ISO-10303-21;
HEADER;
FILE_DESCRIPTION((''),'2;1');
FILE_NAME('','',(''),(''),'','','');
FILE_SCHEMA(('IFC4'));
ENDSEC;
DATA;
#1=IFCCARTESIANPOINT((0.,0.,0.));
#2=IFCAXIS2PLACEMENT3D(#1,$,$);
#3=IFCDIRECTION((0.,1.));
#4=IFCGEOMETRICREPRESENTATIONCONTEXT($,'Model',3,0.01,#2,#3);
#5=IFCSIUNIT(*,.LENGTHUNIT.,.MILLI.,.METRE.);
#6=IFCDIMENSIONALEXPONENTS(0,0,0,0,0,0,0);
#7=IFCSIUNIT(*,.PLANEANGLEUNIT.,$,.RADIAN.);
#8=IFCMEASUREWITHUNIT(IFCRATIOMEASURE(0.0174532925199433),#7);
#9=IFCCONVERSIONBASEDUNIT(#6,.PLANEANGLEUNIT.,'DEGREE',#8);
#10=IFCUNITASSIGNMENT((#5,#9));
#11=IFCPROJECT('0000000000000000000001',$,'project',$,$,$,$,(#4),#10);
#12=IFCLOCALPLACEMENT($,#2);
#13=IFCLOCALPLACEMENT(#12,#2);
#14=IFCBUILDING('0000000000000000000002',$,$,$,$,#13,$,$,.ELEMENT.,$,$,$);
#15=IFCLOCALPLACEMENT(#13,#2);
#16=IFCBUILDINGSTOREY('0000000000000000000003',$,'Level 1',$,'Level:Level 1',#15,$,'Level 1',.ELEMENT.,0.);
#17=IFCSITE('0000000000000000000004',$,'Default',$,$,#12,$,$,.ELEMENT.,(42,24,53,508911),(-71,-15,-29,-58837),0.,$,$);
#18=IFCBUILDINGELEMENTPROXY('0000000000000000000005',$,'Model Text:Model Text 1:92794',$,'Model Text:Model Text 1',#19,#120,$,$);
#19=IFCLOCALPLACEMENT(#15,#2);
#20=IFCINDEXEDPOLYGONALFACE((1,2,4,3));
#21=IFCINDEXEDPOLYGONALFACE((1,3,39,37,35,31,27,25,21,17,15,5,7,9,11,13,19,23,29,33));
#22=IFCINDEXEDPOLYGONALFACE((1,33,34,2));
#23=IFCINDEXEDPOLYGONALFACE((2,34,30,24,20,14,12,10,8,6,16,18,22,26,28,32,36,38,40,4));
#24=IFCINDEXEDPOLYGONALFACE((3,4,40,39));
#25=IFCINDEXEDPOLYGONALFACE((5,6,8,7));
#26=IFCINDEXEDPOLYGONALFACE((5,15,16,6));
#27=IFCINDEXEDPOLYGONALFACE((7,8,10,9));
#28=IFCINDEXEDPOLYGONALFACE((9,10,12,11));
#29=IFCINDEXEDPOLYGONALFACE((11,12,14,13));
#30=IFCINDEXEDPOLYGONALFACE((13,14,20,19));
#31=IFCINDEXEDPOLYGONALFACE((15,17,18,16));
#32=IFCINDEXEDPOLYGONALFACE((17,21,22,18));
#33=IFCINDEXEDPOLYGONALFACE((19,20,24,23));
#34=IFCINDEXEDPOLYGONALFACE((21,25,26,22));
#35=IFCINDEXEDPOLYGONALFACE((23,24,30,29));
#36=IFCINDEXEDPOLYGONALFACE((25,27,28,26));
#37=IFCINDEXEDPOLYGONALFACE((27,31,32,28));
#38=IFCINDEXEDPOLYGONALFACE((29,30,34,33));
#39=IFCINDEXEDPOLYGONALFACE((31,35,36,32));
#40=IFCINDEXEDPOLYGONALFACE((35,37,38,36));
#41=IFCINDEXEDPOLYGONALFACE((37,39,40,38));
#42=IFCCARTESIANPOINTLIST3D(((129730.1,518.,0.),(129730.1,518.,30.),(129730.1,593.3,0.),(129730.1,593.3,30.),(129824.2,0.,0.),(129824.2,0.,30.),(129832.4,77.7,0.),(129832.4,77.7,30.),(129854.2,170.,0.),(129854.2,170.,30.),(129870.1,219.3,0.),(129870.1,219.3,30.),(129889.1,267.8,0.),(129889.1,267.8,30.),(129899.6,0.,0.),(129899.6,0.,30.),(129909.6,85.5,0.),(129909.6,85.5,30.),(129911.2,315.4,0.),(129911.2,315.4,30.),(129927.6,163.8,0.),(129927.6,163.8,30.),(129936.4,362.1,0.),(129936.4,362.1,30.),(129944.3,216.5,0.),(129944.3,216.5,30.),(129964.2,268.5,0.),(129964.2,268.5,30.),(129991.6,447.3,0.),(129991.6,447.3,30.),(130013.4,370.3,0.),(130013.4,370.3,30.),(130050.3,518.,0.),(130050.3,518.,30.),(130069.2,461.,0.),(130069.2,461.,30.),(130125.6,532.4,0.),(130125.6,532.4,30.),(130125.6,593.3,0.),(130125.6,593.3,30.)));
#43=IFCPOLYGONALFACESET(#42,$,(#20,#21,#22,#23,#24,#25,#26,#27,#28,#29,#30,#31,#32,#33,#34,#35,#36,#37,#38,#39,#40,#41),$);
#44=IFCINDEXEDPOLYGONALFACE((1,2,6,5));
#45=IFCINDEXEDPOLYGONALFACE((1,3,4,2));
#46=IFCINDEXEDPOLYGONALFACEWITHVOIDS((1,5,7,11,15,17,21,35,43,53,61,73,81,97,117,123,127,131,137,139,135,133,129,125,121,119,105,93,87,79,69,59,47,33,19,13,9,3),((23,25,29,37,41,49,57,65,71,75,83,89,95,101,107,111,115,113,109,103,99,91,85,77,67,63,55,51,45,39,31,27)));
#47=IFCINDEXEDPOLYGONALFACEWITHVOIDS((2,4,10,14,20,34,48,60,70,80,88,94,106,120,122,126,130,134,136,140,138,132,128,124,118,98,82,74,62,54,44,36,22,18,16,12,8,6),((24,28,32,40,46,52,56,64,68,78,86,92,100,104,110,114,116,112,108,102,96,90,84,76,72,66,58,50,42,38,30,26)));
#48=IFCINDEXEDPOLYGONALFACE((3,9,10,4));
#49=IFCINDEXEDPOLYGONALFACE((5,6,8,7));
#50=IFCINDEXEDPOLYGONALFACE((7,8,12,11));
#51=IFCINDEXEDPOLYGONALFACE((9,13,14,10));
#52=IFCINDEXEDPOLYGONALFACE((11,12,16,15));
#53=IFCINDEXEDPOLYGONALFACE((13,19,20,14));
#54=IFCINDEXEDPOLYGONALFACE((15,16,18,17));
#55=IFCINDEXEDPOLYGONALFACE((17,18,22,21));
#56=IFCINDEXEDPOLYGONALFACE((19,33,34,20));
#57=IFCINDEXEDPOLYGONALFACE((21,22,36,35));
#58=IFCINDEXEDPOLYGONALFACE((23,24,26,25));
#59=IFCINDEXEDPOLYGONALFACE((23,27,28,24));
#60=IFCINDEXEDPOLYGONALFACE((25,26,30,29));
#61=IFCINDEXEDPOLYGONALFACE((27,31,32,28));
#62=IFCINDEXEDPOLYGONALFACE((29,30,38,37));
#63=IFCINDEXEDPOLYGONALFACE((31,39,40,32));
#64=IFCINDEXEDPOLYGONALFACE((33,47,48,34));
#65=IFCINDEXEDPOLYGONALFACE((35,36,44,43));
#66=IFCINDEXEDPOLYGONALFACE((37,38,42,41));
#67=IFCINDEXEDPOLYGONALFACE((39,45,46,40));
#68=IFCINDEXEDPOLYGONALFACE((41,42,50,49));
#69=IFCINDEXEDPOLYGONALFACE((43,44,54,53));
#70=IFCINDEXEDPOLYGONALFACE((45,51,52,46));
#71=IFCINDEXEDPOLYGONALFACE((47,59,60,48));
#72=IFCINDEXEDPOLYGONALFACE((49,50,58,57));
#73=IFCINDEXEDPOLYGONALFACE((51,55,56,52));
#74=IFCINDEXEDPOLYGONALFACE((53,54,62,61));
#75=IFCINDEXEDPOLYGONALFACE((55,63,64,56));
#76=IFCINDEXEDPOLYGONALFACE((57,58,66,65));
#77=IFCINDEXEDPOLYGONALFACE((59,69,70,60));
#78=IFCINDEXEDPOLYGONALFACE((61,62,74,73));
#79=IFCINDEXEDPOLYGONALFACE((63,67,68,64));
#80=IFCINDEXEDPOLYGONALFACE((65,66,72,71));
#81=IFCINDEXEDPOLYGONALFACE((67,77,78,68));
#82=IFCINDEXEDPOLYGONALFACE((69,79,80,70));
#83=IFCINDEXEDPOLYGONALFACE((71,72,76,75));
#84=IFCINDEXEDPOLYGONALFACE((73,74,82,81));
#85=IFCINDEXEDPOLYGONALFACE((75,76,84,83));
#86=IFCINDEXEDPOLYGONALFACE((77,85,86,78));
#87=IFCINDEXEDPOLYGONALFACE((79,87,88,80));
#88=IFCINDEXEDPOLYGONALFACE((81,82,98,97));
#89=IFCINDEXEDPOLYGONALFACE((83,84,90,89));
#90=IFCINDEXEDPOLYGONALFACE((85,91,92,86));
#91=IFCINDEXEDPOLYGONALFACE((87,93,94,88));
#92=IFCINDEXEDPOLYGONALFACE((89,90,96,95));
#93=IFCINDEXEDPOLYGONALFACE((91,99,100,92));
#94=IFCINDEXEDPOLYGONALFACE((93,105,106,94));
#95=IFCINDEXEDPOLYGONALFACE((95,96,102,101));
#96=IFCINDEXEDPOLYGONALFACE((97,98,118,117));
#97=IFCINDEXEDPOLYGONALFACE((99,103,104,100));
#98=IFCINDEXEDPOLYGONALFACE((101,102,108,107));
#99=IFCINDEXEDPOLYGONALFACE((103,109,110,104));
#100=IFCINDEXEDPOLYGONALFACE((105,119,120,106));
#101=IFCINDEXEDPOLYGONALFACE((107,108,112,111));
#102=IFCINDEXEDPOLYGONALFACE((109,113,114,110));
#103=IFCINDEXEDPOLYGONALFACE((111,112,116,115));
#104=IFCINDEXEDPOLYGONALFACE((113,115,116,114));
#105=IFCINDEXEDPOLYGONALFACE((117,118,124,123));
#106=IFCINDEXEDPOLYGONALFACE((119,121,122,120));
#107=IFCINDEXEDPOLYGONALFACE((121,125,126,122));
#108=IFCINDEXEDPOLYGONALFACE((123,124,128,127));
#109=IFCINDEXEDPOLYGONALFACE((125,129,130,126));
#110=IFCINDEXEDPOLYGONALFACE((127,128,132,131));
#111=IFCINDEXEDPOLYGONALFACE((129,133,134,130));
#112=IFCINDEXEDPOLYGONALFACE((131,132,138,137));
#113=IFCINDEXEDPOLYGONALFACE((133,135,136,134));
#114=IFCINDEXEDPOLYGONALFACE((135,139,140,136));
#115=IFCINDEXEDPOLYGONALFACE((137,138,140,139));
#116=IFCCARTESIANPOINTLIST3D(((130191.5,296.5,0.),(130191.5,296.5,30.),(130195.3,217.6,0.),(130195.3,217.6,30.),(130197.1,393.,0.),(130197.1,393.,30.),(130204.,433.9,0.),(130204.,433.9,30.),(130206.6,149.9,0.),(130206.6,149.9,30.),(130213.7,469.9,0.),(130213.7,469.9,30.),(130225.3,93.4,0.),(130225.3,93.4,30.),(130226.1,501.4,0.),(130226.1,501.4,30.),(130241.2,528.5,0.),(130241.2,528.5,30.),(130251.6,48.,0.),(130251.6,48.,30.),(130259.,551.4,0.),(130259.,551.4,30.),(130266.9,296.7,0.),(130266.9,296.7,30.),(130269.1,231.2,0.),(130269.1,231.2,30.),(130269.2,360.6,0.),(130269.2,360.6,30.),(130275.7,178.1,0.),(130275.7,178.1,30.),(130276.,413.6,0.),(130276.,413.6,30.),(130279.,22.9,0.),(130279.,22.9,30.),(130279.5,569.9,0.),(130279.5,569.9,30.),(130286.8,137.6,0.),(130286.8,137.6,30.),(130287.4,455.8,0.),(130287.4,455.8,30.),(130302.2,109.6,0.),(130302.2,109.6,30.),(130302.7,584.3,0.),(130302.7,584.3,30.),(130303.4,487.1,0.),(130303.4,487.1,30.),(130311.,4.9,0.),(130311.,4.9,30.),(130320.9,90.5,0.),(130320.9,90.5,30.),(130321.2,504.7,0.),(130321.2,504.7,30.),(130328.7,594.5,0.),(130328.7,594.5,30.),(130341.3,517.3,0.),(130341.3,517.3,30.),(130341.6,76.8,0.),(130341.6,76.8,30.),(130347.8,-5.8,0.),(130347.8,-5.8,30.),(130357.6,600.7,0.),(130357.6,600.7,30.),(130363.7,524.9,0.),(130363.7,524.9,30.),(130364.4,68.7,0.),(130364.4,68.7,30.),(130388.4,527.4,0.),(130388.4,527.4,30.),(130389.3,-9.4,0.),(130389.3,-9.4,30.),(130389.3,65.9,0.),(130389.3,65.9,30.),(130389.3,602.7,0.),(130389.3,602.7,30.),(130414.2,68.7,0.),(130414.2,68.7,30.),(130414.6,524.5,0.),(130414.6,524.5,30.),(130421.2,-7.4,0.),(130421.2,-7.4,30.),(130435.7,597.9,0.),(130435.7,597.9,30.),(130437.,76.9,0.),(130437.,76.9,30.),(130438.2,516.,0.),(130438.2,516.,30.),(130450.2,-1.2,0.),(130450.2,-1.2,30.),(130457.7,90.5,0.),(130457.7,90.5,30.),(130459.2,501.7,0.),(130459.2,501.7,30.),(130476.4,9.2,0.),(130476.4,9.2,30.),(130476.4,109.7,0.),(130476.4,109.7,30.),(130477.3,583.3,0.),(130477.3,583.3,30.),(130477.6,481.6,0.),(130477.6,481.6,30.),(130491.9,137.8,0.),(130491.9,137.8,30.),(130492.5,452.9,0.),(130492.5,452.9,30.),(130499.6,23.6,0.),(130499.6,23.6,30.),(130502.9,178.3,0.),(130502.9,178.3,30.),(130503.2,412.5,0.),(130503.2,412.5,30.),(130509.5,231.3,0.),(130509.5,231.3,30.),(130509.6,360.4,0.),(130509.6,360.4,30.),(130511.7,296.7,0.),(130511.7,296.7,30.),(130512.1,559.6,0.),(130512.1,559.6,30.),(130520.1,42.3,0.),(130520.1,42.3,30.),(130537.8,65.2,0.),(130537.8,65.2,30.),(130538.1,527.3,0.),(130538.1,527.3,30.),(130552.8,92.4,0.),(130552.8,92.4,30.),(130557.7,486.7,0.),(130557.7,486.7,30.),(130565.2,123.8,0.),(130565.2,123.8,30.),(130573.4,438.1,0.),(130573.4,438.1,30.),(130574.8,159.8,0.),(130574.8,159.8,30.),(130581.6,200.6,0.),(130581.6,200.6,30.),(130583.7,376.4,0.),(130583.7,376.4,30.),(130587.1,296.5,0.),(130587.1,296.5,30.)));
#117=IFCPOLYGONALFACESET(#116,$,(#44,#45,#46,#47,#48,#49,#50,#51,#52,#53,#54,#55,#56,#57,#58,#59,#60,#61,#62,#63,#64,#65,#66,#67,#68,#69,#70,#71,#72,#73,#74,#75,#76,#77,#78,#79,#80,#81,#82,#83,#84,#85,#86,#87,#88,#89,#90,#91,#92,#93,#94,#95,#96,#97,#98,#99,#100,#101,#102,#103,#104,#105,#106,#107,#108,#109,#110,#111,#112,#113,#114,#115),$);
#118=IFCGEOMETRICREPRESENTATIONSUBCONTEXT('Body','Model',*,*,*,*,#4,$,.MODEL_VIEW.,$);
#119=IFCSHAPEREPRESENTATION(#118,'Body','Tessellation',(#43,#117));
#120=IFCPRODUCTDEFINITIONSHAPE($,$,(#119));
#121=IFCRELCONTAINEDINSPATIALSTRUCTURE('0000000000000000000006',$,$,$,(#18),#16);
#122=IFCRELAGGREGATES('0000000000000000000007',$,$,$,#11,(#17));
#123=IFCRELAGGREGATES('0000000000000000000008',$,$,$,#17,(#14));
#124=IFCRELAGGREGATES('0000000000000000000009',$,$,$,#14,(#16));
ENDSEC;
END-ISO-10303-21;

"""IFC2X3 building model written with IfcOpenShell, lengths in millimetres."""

from ifc_helpers import new_model, entity, si_unit, converted_unit, direction, frame, origin, place, context, subcontext, project, spatial, polyline, outline, extrude, element, save


model = new_model("IFC2X3")

# Units and contexts
model_context = context("Model", 3, precision=0.01, world=origin(), true_north=direction((0.0, 1.0)))
body_context = subcontext(model_context, "Body", "Model", "MODEL_VIEW")
ifc_project = project(units=[si_unit("LENGTHUNIT", "METRE", prefix="MILLI"), converted_unit("PLANEANGLEUNIT", "DEGREE", entity("IfcRatioMeasure", 0.0174532925199433), si_unit("PLANEANGLEUNIT", "RADIAN"), dimensions=[0, 0, 0, 0, 0, 0, 0])], contexts=[model_context])

# Site, building, storey
site_placement = place(None, origin())
site = spatial("IfcSite", under=ifc_project, at=site_placement, Name="Default", CompositionType="ELEMENT", RefLatitude=(42, 24, 53, 508911), RefLongitude=(-71, -15, -29, -58837), RefElevation=0.0)
building_placement = place(site_placement, origin())
building = spatial("IfcBuilding", under=site, at=building_placement, CompositionType="ELEMENT")
storey_placement = place(building_placement, origin())
storey = spatial("IfcBuildingStorey", under=building, at=storey_placement, Name="Level 1", ObjectType="Level:Level 1", LongName="Level 1", CompositionType="ELEMENT", Elevation=0.0)

# Building element proxy
proxy_1_placement = place(storey_placement, origin())
element("IfcBuildingElementProxy", 1, at=proxy_1_placement, inside=storey, Name="Model Text:Model Text 1:92794", ObjectType="Model Text:Model Text 1", context=body_context, shape_type="SweptSolid", body=[
    extrude(outline(polyline([(-199.9, -209.0), (-199.9, -284.3), (195.7, -284.3), (195.7, -223.4), (139.3, -152.0), (83.5, -61.3), (34.2, 40.5), (14.4, 92.5), (-2.4, 145.2), (-20.3, 223.5), (-30.3, 309.0), (-105.7, 309.0), (-97.5, 231.3), (-75.7, 139.0), (-59.9, 89.7), (-40.9, 41.2), (-18.8, -6.4), (6.4, -53.1), (61.7, -138.3), (120.3, -209.0), (-199.9, -209.0)])), frame((129929.9, 309.0, 0.0), z_axis=(0.0, 0.0, -1.0), x_axis=(1.0, 0.0, 0.0)), (0.0, 0.0, -1.0), 30.0),
    extrude(outline(polyline([(-10.6, -198.7), (68.3, -198.7), (136.5, -190.7), (193.9, -174.7), (240.5, -150.6), (266.9, -124.4), (286.3, -93.2), (298.8, -57.0), (304.3, -15.7), (303.8, 16.2), (299.0, 45.5), (289.9, 72.1), (276.6, 96.0), (258.9, 117.3), (236.9, 136.2), (210.4, 152.5), (179.6, 166.3), (144.1, 177.6), (103.7, 186.3), (8.2, 196.4), (-71.8, 196.7), (-134.0, 189.4), (-183.3, 176.1), (-224.7, 158.4), (-258.2, 133.9), (-283.5, 100.3), (-300.1, 59.5), (-307.1, 13.4), (-306.6, -18.4), (-301.8, -47.5), (-292.8, -74.0), (-279.6, -97.9), (-262.0, -119.2), (-240.0, -138.1), (-213.6, -154.5), (-182.8, -168.4), (-147.3, -179.8), (-106.7, -188.6), (-10.6, -198.7)]), holes=[polyline([(-7.2, -123.5), (-71.0, -118.2), (-123.6, -108.8), (-165.2, -95.4), (-195.7, -78.0), (-212.4, -59.4), (-224.1, -38.7), (-230.6, -15.9), (-231.9, 8.9), (-227.8, 35.0), (-218.1, 58.1), (-202.8, 78.4), (-182.0, 95.8), (-152.6, 109.4), (-111.7, 118.1), (-59.4, 122.0), (4.4, 121.1), (69.6, 115.8), (122.2, 106.7), (162.2, 93.7), (189.5, 77.0), (207.7, 57.4), (220.4, 36.0), (227.5, 12.8), (229.1, -12.1), (225.2, -36.8), (215.9, -59.2), (201.3, -79.3), (181.4, -97.1), (152.6, -111.2), (111.6, -120.3), (58.3, -124.4), (-7.2, -123.5)])]), frame((130390.6, 295.3, 0.0), z_axis=(0.0, 0.0, 1.0), x_axis=(0.047515, -0.998871, 0.0)), (0.0, 0.0, 1.0), 30.0),
])

save(model, "model.ifc")
